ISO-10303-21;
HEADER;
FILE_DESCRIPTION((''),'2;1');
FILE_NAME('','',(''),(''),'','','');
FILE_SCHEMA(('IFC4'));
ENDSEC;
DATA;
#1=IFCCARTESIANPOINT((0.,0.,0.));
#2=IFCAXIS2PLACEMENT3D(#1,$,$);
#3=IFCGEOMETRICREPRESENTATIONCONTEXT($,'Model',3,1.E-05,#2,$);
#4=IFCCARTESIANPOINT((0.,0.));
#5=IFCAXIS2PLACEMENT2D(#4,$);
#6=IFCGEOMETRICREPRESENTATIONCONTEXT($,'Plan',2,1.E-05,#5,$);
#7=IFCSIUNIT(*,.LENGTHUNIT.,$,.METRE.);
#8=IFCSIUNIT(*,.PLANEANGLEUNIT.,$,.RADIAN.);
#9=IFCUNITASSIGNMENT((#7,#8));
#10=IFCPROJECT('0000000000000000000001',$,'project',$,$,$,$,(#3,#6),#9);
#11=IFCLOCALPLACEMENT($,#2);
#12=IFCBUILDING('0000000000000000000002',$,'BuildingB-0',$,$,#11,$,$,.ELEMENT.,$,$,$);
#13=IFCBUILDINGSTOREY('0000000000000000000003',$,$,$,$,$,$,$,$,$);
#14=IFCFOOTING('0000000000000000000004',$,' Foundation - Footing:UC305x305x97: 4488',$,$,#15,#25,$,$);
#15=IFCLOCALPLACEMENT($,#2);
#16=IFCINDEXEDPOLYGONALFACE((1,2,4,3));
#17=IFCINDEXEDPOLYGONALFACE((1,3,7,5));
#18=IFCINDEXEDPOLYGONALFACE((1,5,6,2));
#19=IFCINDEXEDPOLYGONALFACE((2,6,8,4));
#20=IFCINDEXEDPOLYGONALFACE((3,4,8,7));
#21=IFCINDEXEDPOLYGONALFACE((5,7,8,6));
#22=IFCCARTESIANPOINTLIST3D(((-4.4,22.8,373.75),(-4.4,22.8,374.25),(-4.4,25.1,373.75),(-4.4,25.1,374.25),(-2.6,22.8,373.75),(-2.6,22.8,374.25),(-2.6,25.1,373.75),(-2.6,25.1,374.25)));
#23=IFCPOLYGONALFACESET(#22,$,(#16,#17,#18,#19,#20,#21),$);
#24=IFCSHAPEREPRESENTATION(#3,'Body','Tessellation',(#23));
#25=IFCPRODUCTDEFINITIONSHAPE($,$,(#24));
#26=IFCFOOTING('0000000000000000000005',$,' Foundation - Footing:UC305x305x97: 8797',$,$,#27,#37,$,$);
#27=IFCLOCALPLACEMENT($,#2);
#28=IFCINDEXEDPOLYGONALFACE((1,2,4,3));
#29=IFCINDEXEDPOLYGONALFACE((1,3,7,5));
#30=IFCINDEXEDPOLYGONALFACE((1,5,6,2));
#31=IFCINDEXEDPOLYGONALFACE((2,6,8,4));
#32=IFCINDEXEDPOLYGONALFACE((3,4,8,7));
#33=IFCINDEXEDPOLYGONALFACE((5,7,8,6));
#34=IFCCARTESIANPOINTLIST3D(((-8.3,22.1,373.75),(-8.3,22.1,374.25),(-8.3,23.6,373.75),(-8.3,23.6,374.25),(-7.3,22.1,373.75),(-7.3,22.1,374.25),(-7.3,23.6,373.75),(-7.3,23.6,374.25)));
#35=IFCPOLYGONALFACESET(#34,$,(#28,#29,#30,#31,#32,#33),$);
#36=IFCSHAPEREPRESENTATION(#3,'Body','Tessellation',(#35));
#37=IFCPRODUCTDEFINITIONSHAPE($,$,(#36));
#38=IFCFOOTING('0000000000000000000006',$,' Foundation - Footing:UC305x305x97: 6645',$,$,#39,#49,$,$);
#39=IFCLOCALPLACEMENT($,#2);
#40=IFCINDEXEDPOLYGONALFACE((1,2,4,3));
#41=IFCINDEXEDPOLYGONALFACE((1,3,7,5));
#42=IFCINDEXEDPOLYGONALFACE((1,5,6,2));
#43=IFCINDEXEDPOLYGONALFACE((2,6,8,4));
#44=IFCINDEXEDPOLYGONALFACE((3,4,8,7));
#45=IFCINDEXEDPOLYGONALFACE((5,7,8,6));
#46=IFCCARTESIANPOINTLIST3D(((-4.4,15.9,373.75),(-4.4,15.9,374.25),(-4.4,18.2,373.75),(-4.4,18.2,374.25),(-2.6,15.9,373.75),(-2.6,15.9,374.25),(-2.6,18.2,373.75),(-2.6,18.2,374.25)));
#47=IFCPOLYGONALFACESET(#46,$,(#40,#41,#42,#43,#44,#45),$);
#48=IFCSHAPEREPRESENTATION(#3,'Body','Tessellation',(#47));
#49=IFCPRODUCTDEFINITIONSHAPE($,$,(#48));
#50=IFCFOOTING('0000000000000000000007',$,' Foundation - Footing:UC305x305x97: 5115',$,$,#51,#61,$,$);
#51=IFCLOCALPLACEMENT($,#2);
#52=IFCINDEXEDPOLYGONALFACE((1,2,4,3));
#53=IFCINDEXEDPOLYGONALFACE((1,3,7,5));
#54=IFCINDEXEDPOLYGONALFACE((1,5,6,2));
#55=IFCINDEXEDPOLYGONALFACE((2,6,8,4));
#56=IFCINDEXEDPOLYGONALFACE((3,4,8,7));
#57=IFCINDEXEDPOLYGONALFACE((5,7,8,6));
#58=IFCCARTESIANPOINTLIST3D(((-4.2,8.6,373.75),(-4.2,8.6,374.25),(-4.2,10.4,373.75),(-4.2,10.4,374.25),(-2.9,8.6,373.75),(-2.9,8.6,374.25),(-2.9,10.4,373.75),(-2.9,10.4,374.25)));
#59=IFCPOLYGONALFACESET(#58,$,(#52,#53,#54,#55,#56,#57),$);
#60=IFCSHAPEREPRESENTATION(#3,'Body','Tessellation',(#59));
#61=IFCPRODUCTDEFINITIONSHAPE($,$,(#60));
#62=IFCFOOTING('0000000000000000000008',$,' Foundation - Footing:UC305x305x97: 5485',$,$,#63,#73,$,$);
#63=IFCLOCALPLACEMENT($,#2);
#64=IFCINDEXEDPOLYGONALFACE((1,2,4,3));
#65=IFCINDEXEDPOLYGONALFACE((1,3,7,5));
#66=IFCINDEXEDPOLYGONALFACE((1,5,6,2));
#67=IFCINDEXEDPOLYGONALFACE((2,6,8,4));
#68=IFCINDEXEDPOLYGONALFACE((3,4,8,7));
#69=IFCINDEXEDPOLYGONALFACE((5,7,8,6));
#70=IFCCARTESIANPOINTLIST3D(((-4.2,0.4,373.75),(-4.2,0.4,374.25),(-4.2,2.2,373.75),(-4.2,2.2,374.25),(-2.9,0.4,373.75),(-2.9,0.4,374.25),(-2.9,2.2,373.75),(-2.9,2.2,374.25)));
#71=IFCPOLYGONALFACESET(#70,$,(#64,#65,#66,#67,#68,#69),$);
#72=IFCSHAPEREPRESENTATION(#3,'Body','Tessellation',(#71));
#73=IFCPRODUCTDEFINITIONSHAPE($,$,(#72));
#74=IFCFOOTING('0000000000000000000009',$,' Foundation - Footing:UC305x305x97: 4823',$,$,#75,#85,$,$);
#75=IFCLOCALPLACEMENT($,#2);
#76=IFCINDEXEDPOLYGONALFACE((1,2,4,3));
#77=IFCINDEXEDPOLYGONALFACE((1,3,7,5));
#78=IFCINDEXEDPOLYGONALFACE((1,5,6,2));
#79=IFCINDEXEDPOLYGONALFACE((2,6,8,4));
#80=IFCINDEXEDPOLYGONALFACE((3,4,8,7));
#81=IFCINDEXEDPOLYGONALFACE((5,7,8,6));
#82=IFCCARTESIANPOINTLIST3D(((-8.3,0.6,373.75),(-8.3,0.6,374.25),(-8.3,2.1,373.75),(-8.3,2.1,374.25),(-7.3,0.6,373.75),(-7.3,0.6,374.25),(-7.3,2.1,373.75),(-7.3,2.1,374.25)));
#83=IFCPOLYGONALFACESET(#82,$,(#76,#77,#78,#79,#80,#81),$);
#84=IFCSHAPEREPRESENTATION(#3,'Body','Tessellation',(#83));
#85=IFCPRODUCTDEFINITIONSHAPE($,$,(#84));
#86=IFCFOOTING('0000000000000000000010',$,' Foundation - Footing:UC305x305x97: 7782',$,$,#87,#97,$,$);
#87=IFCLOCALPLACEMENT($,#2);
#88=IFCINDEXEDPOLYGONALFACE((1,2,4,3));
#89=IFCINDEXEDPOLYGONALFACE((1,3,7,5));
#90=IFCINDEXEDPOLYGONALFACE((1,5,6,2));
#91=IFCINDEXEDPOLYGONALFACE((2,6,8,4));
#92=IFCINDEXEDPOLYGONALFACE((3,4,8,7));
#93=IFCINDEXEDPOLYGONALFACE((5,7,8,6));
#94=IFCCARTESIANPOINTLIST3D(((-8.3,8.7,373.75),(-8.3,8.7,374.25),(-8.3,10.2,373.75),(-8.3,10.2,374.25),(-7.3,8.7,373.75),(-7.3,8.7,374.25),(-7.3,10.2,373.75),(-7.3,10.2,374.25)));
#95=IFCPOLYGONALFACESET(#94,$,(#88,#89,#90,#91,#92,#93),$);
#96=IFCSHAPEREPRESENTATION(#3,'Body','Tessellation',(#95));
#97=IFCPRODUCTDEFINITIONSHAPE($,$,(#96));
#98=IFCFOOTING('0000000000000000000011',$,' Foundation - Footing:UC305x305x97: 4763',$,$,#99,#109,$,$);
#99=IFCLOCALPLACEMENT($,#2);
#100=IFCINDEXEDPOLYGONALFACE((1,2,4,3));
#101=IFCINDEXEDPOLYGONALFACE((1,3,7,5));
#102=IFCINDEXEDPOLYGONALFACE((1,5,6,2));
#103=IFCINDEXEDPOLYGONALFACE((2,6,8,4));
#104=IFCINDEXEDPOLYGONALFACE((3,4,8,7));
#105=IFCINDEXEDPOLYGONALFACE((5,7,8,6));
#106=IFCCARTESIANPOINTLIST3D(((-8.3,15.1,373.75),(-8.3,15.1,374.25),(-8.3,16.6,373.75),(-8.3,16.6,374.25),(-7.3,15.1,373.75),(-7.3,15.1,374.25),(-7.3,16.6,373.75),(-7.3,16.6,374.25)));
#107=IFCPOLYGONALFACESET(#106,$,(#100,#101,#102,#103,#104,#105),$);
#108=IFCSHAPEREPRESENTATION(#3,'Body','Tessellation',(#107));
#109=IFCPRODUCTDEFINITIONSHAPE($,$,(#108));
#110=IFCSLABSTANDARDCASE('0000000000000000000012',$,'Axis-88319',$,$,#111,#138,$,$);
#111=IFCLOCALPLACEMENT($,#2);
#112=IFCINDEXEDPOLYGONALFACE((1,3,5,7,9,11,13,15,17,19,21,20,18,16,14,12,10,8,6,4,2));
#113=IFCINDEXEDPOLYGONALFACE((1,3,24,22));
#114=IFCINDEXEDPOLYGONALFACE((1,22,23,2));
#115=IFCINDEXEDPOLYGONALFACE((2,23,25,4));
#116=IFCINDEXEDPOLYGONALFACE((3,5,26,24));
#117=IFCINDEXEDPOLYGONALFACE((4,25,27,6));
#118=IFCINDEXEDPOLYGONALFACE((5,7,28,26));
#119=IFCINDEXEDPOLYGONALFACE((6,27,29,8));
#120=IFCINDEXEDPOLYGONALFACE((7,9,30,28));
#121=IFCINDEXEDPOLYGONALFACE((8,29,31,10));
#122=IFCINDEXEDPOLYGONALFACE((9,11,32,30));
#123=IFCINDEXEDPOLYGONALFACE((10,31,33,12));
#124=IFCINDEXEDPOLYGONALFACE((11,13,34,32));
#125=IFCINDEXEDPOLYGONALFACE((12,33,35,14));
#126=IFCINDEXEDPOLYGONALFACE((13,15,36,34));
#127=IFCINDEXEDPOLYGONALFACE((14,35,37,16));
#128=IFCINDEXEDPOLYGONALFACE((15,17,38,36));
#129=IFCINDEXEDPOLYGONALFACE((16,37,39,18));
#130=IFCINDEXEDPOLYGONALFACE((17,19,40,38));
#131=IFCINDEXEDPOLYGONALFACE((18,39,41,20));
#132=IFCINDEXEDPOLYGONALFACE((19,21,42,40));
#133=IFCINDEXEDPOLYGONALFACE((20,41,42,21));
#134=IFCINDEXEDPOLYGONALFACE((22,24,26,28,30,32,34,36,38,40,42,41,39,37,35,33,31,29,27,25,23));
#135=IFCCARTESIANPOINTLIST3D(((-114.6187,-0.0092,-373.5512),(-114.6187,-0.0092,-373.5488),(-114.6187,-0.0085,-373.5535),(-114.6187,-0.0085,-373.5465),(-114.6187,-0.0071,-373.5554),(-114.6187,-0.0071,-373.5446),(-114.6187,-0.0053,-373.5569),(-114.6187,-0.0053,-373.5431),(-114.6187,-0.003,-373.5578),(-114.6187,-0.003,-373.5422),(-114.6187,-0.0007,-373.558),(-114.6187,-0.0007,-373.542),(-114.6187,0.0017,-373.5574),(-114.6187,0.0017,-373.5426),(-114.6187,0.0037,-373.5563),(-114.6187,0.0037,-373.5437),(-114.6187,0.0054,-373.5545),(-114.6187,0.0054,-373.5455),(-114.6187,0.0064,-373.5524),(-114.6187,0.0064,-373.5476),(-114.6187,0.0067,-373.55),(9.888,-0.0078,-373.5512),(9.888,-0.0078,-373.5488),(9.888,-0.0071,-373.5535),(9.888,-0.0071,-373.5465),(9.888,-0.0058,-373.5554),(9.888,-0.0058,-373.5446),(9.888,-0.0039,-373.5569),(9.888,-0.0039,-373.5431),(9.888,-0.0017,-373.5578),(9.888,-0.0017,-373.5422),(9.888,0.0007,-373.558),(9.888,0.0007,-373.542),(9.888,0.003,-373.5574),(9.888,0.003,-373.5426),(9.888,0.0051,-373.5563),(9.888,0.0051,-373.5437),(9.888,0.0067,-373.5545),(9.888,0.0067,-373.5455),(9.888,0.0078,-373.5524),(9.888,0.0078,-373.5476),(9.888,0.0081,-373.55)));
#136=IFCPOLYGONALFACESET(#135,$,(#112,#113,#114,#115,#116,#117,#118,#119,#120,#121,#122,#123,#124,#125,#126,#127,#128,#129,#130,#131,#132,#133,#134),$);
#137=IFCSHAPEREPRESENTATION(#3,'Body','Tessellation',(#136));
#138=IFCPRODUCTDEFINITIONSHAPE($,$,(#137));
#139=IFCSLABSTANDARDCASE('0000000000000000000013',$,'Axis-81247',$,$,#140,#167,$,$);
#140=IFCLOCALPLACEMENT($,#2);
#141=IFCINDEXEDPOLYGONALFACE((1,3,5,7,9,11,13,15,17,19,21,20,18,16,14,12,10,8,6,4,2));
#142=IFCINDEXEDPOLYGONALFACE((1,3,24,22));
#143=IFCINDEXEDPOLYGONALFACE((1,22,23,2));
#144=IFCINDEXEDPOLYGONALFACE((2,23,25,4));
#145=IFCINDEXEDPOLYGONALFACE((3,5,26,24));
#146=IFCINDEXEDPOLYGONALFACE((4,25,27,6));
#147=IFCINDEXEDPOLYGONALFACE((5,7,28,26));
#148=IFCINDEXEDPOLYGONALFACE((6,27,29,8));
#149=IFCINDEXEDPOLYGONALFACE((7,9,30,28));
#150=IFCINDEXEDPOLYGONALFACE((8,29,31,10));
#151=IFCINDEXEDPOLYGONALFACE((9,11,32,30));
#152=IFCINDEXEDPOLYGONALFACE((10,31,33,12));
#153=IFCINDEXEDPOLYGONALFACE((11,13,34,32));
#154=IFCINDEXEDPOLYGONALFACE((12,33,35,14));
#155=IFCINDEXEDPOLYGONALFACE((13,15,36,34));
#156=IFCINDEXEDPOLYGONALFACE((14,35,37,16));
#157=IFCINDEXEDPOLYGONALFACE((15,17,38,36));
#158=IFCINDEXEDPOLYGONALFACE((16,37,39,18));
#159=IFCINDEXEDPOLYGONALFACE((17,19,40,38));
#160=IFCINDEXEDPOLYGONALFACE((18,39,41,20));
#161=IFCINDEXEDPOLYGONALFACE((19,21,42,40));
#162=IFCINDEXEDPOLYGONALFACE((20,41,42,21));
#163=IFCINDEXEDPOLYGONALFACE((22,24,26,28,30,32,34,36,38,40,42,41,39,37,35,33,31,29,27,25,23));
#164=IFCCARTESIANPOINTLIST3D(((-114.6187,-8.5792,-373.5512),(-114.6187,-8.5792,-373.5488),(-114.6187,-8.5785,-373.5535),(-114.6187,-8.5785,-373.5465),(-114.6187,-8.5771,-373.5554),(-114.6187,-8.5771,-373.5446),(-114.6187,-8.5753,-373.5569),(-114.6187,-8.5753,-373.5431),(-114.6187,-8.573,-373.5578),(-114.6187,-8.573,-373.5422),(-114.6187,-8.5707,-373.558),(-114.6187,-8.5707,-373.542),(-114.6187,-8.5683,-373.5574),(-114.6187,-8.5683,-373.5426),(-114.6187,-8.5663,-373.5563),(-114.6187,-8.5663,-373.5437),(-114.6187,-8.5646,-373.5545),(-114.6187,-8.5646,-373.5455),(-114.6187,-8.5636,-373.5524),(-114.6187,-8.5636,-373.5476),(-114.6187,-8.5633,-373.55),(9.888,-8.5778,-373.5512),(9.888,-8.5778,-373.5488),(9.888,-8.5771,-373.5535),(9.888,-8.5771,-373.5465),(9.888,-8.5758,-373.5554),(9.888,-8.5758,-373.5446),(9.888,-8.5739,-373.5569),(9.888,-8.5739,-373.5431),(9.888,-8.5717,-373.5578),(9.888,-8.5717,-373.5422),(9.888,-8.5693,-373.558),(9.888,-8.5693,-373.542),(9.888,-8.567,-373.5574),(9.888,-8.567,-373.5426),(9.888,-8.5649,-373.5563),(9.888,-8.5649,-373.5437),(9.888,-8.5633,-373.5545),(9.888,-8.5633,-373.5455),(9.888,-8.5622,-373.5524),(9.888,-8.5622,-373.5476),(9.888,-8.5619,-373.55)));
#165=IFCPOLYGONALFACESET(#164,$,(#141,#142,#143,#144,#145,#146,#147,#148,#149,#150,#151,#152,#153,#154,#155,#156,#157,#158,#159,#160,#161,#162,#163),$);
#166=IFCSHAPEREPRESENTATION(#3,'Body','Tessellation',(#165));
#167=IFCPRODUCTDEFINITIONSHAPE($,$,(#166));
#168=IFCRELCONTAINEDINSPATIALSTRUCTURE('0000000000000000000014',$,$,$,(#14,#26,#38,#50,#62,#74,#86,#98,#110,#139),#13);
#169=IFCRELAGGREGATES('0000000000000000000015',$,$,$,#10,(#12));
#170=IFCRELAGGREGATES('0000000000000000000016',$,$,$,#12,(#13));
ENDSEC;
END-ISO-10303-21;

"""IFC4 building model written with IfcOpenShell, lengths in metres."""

from ifc_helpers import new_model, entity, si_unit, origin, origin_2d, place, context, project, spatial, polyline, outline, extrude, element, save


model = new_model("IFC4")

# Units and contexts
model_context = context("Model", 3, precision=1e-05, world=origin())
plan_context = context("Plan", 2, precision=1e-05, world=origin_2d())
ifc_project = project(units=[si_unit("LENGTHUNIT", "METRE"), si_unit("PLANEANGLEUNIT", "RADIAN")], contexts=[model_context, plan_context])

# Building, storey
building_placement = place(None, origin())
building = spatial("IfcBuilding", under=ifc_project, at=building_placement, Name="BuildingB-0", CompositionType="ELEMENT")
storey = spatial("IfcBuildingStorey", under=building)

# Footings
element("IfcFooting", 1, inside=storey, Name=" Foundation - Footing:UC305x305x97: 4488", context=model_context, shape_type="SweptSolid", body=[
    extrude(outline(polyline([(-4.4, 25.1, 373.75), (-2.6, 25.1, 373.75), (-2.6, 22.8, 373.75), (-4.4, 22.8, 373.75), (-4.4, 25.1, 373.75)])), None, (0.0, 0.0, 1.0), 0.5),
])
element("IfcFooting", 2, inside=storey, Name=" Foundation - Footing:UC305x305x97: 8797", context=model_context, shape_type="SweptSolid", body=[
    extrude(outline(polyline([(-7.3, 23.6, 373.75), (-8.3, 23.6, 373.75), (-8.3, 22.1, 373.75), (-7.3, 22.1, 373.75), (-7.3, 23.6, 373.75)])), None, (0.0, 0.0, 1.0), 0.5),
])
element("IfcFooting", 3, inside=storey, Name=" Foundation - Footing:UC305x305x97: 6645", context=model_context, shape_type="SweptSolid", body=[
    extrude(outline(polyline([(-2.6, 18.2, 373.75), (-4.4, 18.2, 373.75), (-4.4, 15.9, 373.75), (-2.6, 15.9, 373.75), (-2.6, 18.2, 373.75)])), None, (0.0, 0.0, 1.0), 0.5),
])
element("IfcFooting", 4, inside=storey, Name=" Foundation - Footing:UC305x305x97: 5115", context=model_context, shape_type="SweptSolid", body=[
    extrude(outline(polyline([(-2.9, 10.4, 373.75), (-4.2, 10.4, 373.75), (-4.2, 8.6, 373.75), (-2.9, 8.6, 373.75), (-2.9, 10.4, 373.75)])), None, (0.0, 0.0, 1.0), 0.5),
])
element("IfcFooting", 5, inside=storey, Name=" Foundation - Footing:UC305x305x97: 5485", context=model_context, shape_type="SweptSolid", body=[
    extrude(outline(polyline([(-2.9, 2.2, 373.75), (-4.2, 2.2, 373.75), (-4.2, 0.4, 373.75), (-2.9, 0.4, 373.75), (-2.9, 2.2, 373.75)])), None, (0.0, 0.0, 1.0), 0.5),
])
element("IfcFooting", 6, inside=storey, Name=" Foundation - Footing:UC305x305x97: 4823", context=model_context, shape_type="SweptSolid", body=[
    extrude(outline(polyline([(-7.3, 2.1, 373.75), (-8.3, 2.1, 373.75), (-8.3, 0.6, 373.75), (-7.3, 0.6, 373.75), (-7.3, 2.1, 373.75)])), None, (0.0, 0.0, 1.0), 0.5),
])
element("IfcFooting", 7, inside=storey, Name=" Foundation - Footing:UC305x305x97: 7782", context=model_context, shape_type="SweptSolid", body=[
    extrude(outline(polyline([(-7.3, 10.2, 373.75), (-8.3, 10.2, 373.75), (-8.3, 8.7, 373.75), (-7.3, 8.7, 373.75), (-7.3, 10.2, 373.75)])), None, (0.0, 0.0, 1.0), 0.5),
])
element("IfcFooting", 8, inside=storey, Name=" Foundation - Footing:UC305x305x97: 4763", context=model_context, shape_type="SweptSolid", body=[
    extrude(outline(polyline([(-7.3, 16.6, 373.75), (-8.3, 16.6, 373.75), (-8.3, 15.1, 373.75), (-7.3, 15.1, 373.75), (-7.3, 16.6, 373.75)])), None, (0.0, 0.0, 1.0), 0.5),
])

# Slabs
element("IfcSlabStandardCase", 9, inside=storey, Name="Axis-88319", context=model_context, shape_type="AdvancedSweptSolid", body=[
    entity("IfcSurfaceCurveSweptAreaSolid", entity("IfcCircleProfileDef", "AREA", None, None, 0.008), None, entity("IfcPolyline", [entity("IfcCartesianPoint", [-9.888, -0.0001, 373.55]), entity("IfcCartesianPoint", [114.6187, 0.0013, 373.55])]), None, None, entity("IfcPlane", entity("IfcAxis2Placement3D", entity("IfcCartesianPoint", [-9.888, -0.0001, 373.55]), entity("IfcDirection", [0.0, 0.0, 1.0]), entity("IfcDirection", [1.0, 0.0, 0.0])))),
    entity("IfcSurfaceCurveSweptAreaSolid", entity("IfcCircleProfileDef", "AREA", None, None, 0.008), None, entity("IfcCircle", entity("IfcAxis2Placement2D", entity("IfcCartesianPoint", [-10.1215, -0.0001, 373.55])), 0.35), None, None, entity("IfcPlane", entity("IfcAxis2Placement3D", entity("IfcCartesianPoint", [-10.1215, -0.0001, 373.55]), entity("IfcDirection", [0.0, 0.0, 1.0]), entity("IfcDirection", [1.0, 0.0, 0.0])))),
    entity("IfcSurfaceCurveSweptAreaSolid", entity("IfcCircleProfileDef", "AREA", None, None, 0.008), None, entity("IfcCircle", entity("IfcAxis2Placement2D", entity("IfcCartesianPoint", [114.8522, 0.0013, 373.55])), 0.35), None, None, entity("IfcPlane", entity("IfcAxis2Placement3D", entity("IfcCartesianPoint", [114.8522, 0.0013, 373.55]), entity("IfcDirection", [0.0, 0.0, 1.0]), entity("IfcDirection", [1.0, 0.0, 0.0])))),
])
element("IfcSlabStandardCase", 10, inside=storey, Name="Axis-81247", context=model_context, shape_type="AdvancedSweptSolid", body=[
    entity("IfcSurfaceCurveSweptAreaSolid", entity("IfcCircleProfileDef", "AREA", None, None, 0.008), None, entity("IfcPolyline", [entity("IfcCartesianPoint", [-9.888, 8.5699, 373.55]), entity("IfcCartesianPoint", [114.6187, 8.5713, 373.55])]), None, None, entity("IfcPlane", entity("IfcAxis2Placement3D", entity("IfcCartesianPoint", [-9.888, 8.5699, 373.55]), entity("IfcDirection", [0.0, 0.0, 1.0]), entity("IfcDirection", [1.0, 0.0, 0.0])))),
    entity("IfcSurfaceCurveSweptAreaSolid", entity("IfcCircleProfileDef", "AREA", None, None, 0.008), None, entity("IfcCircle", entity("IfcAxis2Placement2D", entity("IfcCartesianPoint", [-10.1215, 8.5699, 373.55])), 0.35), None, None, entity("IfcPlane", entity("IfcAxis2Placement3D", entity("IfcCartesianPoint", [-10.1215, 8.5699, 373.55]), entity("IfcDirection", [0.0, 0.0, 1.0]), entity("IfcDirection", [1.0, 0.0, 0.0])))),
    entity("IfcSurfaceCurveSweptAreaSolid", entity("IfcCircleProfileDef", "AREA", None, None, 0.008), None, entity("IfcCircle", entity("IfcAxis2Placement2D", entity("IfcCartesianPoint", [114.8522, 8.5713, 373.55])), 0.35), None, None, entity("IfcPlane", entity("IfcAxis2Placement3D", entity("IfcCartesianPoint", [114.8522, 8.5713, 373.55]), entity("IfcDirection", [0.0, 0.0, 1.0]), entity("IfcDirection", [1.0, 0.0, 0.0])))),
])

save(model, "model.ifc")
